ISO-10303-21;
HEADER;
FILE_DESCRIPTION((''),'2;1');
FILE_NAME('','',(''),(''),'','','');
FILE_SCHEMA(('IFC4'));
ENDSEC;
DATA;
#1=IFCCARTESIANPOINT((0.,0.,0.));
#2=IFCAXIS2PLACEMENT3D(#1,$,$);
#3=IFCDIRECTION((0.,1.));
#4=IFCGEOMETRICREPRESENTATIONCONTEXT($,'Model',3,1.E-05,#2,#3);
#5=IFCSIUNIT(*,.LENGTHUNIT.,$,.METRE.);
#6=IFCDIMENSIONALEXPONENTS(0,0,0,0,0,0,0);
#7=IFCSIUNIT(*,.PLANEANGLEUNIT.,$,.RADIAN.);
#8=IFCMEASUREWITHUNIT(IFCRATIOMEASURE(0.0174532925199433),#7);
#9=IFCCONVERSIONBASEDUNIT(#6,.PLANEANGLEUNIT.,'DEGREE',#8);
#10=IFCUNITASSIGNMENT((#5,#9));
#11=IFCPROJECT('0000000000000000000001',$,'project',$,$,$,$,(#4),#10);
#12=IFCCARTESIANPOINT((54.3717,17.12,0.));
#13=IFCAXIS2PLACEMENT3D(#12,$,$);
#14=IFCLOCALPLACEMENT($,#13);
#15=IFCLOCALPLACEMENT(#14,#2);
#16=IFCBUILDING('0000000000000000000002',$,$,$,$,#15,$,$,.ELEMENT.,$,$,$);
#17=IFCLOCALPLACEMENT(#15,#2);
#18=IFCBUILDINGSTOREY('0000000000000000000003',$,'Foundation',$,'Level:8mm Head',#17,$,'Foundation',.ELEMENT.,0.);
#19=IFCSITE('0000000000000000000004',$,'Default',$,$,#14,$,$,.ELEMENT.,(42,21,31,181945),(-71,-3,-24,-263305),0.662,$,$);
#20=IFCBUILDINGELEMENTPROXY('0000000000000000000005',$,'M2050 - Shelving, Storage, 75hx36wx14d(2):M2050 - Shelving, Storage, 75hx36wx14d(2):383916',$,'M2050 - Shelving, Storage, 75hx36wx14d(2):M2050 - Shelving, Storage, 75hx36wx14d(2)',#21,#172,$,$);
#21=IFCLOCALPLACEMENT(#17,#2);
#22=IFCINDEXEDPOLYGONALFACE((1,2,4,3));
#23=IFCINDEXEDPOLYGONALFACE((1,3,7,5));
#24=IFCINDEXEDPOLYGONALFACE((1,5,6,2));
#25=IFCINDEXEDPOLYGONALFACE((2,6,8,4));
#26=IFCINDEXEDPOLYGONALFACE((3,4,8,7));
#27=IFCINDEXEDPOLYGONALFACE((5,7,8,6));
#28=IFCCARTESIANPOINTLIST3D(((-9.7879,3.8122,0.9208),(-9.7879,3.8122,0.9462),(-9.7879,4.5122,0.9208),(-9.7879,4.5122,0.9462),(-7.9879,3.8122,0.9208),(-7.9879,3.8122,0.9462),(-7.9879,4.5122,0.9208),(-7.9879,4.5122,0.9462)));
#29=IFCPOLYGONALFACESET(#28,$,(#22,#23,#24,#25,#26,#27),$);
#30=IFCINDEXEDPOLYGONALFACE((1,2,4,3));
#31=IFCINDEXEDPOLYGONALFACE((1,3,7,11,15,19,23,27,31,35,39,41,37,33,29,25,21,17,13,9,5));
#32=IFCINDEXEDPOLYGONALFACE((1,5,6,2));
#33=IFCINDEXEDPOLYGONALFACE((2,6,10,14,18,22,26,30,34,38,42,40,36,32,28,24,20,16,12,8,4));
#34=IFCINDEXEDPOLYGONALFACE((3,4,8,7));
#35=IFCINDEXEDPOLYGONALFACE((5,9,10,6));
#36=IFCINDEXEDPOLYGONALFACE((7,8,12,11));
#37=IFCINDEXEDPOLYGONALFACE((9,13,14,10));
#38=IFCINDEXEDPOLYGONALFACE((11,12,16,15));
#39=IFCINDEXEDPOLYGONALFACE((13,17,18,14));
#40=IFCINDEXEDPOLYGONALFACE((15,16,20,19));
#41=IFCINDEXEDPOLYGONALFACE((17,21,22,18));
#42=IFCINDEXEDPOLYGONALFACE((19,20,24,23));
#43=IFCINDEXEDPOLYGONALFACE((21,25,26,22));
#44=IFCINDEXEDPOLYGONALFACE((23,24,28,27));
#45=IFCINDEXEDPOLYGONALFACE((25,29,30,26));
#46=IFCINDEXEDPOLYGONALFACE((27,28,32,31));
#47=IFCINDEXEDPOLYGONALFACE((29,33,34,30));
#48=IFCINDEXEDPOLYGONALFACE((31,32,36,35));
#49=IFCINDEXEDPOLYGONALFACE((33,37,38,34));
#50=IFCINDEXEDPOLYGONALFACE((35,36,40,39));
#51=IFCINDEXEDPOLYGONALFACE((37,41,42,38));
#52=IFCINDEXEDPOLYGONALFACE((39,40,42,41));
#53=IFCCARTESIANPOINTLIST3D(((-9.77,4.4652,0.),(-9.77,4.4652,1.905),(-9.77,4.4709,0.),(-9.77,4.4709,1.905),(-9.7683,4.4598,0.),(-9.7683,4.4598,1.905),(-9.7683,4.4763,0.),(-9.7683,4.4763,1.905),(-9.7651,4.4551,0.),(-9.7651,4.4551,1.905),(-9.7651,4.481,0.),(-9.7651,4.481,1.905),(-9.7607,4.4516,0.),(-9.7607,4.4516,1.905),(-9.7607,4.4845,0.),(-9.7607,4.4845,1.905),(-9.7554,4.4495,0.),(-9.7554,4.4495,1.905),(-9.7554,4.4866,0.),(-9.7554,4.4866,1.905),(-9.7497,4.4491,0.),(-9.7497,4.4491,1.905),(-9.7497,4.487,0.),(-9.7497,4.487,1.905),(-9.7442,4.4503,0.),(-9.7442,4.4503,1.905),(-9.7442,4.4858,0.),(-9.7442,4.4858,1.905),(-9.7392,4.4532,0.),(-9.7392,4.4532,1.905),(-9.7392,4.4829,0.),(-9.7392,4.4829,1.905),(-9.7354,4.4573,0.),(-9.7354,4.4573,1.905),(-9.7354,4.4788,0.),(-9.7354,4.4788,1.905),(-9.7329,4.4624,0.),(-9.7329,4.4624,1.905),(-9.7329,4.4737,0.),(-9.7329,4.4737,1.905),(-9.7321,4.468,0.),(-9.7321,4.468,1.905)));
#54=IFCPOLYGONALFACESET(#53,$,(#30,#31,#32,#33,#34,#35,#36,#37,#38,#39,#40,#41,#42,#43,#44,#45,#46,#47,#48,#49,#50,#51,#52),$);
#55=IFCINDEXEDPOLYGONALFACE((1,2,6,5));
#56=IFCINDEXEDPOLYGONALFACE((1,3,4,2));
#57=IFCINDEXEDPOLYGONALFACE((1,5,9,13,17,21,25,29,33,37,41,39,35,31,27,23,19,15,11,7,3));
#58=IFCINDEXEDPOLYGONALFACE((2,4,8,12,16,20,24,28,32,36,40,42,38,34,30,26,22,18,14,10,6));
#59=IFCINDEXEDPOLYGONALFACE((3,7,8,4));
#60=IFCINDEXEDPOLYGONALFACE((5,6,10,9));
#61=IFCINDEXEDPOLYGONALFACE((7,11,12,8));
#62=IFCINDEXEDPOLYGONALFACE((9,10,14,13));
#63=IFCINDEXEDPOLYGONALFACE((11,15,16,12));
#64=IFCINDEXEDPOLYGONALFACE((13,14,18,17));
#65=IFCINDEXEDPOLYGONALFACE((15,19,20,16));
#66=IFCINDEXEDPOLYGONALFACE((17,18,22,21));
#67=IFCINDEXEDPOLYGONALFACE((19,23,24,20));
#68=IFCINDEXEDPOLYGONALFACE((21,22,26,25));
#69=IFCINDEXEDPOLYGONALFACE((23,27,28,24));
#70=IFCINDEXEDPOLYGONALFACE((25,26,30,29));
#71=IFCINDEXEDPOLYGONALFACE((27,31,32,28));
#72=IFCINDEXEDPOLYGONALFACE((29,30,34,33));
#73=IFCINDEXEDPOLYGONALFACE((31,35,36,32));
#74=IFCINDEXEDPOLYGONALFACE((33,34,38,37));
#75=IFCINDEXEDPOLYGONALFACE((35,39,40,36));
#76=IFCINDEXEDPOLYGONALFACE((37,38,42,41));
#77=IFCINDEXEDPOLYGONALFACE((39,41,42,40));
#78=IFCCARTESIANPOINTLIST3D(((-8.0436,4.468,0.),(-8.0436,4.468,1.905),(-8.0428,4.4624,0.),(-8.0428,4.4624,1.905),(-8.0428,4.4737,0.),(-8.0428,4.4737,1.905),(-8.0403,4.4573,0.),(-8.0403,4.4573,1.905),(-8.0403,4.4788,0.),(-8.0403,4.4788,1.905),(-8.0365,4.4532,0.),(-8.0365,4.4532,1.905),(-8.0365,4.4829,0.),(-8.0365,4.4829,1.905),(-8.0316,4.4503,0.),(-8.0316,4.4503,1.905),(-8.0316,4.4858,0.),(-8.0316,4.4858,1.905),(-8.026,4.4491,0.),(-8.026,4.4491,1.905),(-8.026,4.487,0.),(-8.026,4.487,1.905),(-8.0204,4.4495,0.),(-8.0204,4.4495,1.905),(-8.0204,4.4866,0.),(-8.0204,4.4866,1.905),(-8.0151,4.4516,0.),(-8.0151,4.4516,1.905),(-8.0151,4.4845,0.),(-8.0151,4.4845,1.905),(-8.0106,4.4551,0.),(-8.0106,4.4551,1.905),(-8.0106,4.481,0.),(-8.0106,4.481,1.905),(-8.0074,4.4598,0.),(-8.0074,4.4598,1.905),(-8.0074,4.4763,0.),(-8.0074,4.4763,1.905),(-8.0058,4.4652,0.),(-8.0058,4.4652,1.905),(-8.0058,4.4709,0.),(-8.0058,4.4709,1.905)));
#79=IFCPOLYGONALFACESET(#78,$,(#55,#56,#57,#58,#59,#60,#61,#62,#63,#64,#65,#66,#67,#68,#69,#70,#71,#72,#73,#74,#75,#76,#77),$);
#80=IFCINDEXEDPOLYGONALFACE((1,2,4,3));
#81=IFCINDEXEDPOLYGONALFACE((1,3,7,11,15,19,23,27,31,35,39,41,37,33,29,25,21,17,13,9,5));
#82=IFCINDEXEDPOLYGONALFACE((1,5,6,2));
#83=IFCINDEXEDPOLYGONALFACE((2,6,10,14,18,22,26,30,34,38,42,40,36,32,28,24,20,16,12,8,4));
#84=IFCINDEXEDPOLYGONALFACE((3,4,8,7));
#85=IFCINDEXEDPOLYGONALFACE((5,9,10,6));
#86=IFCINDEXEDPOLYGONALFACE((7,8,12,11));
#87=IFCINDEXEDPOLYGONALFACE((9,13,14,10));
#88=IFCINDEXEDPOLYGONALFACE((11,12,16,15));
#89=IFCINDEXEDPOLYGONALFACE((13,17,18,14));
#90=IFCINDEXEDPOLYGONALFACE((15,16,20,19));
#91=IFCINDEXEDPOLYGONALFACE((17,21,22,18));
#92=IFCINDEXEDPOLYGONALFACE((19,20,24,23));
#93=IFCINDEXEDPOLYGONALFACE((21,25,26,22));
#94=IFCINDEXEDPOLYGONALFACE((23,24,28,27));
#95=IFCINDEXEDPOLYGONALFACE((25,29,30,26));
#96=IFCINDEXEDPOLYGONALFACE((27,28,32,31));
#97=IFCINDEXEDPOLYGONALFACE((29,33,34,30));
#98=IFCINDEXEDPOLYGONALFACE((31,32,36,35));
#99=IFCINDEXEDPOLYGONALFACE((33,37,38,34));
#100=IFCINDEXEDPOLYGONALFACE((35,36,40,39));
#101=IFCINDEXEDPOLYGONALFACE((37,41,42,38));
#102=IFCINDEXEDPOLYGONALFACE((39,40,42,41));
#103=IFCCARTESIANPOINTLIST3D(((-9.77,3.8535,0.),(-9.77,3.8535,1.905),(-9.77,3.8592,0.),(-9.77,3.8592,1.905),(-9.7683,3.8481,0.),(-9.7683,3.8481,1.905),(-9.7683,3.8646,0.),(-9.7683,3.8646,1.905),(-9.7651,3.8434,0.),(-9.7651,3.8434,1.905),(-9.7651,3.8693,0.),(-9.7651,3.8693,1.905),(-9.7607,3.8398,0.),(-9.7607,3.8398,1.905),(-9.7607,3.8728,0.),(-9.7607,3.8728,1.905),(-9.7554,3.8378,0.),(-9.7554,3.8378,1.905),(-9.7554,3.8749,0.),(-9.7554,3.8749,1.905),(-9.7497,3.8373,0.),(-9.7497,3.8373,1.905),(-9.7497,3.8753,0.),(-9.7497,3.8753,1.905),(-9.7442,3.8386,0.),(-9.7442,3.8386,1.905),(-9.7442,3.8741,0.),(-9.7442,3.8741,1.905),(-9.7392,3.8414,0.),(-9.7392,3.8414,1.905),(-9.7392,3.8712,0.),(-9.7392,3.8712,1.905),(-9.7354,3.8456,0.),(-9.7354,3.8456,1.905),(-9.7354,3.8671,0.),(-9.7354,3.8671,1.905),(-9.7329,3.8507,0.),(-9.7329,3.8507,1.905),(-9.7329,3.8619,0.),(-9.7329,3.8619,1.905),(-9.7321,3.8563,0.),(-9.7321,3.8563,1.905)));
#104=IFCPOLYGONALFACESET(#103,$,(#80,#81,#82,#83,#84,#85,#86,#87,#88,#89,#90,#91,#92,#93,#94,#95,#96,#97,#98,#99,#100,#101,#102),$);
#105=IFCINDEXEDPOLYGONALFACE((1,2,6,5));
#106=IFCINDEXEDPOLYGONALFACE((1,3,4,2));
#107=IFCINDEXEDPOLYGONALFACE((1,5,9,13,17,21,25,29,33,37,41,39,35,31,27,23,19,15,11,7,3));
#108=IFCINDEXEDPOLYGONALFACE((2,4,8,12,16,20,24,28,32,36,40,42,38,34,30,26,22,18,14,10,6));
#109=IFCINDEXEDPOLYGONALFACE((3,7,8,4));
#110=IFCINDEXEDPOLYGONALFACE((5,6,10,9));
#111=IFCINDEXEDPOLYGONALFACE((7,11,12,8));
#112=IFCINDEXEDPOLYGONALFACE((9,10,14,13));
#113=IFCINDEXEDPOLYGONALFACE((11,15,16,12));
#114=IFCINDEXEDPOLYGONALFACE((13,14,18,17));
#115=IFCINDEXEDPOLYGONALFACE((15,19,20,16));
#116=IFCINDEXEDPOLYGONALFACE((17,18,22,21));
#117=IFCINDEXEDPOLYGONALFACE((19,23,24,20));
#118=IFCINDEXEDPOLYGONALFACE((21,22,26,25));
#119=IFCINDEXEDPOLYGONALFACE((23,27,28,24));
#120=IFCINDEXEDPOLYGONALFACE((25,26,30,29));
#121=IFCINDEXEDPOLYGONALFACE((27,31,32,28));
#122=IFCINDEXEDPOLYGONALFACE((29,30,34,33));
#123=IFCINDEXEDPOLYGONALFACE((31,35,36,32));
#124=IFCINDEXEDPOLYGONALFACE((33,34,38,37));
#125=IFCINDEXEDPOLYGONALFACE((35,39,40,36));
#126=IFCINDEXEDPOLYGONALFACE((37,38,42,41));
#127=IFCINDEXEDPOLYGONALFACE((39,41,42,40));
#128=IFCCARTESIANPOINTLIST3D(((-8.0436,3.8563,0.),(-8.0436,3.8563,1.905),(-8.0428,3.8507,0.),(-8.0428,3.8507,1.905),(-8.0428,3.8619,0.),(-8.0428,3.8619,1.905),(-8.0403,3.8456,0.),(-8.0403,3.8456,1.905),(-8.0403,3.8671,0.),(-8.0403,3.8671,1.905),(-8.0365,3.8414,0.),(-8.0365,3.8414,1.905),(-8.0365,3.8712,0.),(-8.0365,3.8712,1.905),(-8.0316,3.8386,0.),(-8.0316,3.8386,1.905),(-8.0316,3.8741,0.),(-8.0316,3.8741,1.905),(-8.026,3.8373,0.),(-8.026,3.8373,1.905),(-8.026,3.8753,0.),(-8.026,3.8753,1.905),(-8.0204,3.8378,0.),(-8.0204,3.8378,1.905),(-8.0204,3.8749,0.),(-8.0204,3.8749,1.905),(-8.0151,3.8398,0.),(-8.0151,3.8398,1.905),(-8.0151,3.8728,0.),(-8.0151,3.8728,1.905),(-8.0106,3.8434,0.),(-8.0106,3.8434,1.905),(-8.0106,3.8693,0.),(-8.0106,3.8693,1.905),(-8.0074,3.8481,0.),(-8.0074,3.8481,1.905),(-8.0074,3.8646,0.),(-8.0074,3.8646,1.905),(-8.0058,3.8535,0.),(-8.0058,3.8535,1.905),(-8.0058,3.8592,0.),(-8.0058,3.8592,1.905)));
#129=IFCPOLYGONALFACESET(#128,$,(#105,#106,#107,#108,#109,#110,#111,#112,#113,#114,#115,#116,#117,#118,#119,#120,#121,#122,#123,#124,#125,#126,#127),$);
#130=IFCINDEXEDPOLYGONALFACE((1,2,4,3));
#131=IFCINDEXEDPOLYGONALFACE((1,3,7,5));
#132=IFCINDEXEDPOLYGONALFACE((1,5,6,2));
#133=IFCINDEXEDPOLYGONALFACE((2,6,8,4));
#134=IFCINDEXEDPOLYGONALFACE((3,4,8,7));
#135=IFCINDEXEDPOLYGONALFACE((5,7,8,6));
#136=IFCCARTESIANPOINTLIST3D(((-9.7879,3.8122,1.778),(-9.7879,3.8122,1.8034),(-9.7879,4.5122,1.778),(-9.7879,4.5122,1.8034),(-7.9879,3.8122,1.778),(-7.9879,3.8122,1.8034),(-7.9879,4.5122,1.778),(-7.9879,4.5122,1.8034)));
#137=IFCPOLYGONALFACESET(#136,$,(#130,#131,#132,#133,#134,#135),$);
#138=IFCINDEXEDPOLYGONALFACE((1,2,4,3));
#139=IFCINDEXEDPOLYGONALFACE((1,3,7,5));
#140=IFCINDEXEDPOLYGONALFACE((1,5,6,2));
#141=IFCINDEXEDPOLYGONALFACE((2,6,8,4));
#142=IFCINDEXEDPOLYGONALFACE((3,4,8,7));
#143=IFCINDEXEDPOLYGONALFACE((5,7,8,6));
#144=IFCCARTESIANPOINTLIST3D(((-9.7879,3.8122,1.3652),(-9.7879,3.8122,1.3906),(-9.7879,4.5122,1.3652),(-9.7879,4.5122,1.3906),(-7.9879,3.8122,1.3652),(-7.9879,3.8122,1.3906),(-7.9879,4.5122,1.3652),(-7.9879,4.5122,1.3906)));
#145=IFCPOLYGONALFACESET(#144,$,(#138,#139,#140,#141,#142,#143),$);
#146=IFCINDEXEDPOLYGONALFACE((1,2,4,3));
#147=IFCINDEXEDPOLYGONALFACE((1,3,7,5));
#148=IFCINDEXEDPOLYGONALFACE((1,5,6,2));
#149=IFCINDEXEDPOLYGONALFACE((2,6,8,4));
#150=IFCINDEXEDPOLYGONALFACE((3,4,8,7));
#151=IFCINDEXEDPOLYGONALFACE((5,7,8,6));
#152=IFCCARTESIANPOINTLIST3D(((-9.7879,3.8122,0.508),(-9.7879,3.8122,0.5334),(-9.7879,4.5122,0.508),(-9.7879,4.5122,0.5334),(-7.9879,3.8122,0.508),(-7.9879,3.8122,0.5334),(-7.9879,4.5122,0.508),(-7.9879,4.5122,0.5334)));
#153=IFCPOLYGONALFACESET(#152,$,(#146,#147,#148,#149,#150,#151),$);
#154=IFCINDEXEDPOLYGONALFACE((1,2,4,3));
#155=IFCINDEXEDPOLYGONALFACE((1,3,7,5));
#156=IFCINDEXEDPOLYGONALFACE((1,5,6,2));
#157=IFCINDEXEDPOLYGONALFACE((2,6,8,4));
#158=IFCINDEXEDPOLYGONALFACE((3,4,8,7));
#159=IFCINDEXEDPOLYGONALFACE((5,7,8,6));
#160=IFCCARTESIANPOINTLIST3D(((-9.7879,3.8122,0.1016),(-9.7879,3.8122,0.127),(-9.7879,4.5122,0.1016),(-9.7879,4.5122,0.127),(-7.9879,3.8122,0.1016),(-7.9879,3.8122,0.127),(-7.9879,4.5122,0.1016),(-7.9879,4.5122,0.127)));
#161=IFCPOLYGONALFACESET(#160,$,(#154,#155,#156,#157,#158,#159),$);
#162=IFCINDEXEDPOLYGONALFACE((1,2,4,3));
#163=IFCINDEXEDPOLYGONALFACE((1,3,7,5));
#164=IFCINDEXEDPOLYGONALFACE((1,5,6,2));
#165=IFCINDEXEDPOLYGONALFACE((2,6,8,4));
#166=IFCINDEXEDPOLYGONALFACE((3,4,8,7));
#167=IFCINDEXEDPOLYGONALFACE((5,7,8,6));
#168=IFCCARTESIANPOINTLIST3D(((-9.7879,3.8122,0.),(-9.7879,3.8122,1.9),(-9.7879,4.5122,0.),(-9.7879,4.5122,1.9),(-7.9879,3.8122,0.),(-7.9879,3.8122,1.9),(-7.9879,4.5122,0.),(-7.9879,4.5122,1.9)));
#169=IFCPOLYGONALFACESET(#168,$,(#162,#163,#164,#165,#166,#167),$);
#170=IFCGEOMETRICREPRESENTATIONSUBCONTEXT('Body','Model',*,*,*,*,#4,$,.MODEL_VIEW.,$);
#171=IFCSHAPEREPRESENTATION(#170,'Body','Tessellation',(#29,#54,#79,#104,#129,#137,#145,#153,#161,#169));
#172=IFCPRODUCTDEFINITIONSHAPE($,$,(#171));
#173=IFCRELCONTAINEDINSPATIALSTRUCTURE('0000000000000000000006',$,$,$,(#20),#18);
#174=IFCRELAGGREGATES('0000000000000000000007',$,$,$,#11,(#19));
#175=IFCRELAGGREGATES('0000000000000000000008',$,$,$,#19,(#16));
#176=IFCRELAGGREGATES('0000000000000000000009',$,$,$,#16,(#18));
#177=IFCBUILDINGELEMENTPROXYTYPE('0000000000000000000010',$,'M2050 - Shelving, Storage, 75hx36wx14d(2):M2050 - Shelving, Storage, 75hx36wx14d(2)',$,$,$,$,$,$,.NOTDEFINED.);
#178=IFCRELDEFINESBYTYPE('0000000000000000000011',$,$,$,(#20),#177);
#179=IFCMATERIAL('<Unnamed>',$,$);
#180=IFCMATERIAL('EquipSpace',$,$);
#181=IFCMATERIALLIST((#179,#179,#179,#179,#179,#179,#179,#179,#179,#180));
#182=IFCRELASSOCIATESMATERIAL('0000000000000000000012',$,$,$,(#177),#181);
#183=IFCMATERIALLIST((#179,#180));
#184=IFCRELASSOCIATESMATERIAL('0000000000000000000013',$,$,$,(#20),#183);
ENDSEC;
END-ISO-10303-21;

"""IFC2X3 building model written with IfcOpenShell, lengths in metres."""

from ifc_helpers import new_model, entity, si_unit, converted_unit, direction, frame, frame_2d, origin, origin_2d_with_axis, place, context, subcontext, project, spatial, rectangle, circle, extrude, source, transform, mapped, material, material_list, type_object, type_shapes, element, save


model = new_model("IFC2X3")

# Units and contexts
model_context = context("Model", 3, precision=1e-05, world=origin(), true_north=direction((0.0, 1.0)))
body_context = subcontext(model_context, "Body", "Model", "MODEL_VIEW")
ifc_project = project(units=[si_unit("LENGTHUNIT", "METRE"), converted_unit("PLANEANGLEUNIT", "DEGREE", entity("IfcRatioMeasure", 0.0174532925199433), si_unit("PLANEANGLEUNIT", "RADIAN"), dimensions=[0, 0, 0, 0, 0, 0, 0])], contexts=[model_context])

# Site, building, storey
site_placement = place(None, frame((54.3717, 17.12, 0.0)))
site = spatial("IfcSite", under=ifc_project, at=site_placement, Name="Default", CompositionType="ELEMENT", RefLatitude=(42, 21, 31, 181945), RefLongitude=(-71, -3, -24, -263305), RefElevation=0.662)
building_placement = place(site_placement, origin())
building = spatial("IfcBuilding", under=site, at=building_placement, CompositionType="ELEMENT")
storey_placement = place(building_placement, origin())
storey = spatial("IfcBuildingStorey", under=building, at=storey_placement, Name="Foundation", ObjectType="Level:8mm Head", LongName="Foundation", CompositionType="ELEMENT", Elevation=0.0)

# Building element proxy
ifc_material_1 = material(Name="<Unnamed>")
ifc_material_2 = material(Name="EquipSpace")
ifc_material_list_1 = material_list([ifc_material_1, ifc_material_1, ifc_material_1, ifc_material_1, ifc_material_1, ifc_material_1, ifc_material_1, ifc_material_1, ifc_material_1, ifc_material_2])
building_element_proxy_type = type_object("IfcBuildingElementProxyType", Name="M2050 - Shelving, Storage, 75hx36wx14d(2):M2050 - Shelving, Storage, 75hx36wx14d(2)", PredefinedType="NOTDEFINED", material=ifc_material_list_1)
shared_shape = source(origin(), body_context, "Body", "SweptSolid", [
    extrude(rectangle(XDim=1.8, YDim=0.7, at=origin_2d_with_axis()), frame((0.0, 0.0, 0.9207), z_axis=(0.0, 0.0, 1.0), x_axis=(-1.0, 0.0, 0.0)), (0.0, 0.0, 1.0), 0.0254),
    extrude(circle(Radius=0.0191, at=origin_2d_with_axis()), frame((0.8633, -0.3059, 0.0), z_axis=(0.0, 0.0, 1.0), x_axis=(-1.0, 0.0, 0.0)), (0.0, 0.0, 1.0), 1.905),
    extrude(circle(Radius=0.0191, at=origin_2d_with_axis()), frame((-0.8633, -0.3059, 0.0)), (0.0, 0.0, 1.0), 1.905),
    extrude(circle(Radius=0.0191, at=origin_2d_with_axis()), frame((0.8633, 0.3059, 0.0), z_axis=(0.0, 0.0, 1.0), x_axis=(-1.0, 0.0, 0.0)), (0.0, 0.0, 1.0), 1.905),
    extrude(circle(Radius=0.0191, at=origin_2d_with_axis()), frame((-0.8633, 0.3059, 0.0)), (0.0, 0.0, 1.0), 1.905),
    extrude(rectangle(XDim=1.8, YDim=0.7, at=origin_2d_with_axis()), frame((0.0, 0.0, 1.778), z_axis=(0.0, 0.0, 1.0), x_axis=(-1.0, 0.0, 0.0)), (0.0, 0.0, 1.0), 0.0254),
    extrude(rectangle(XDim=1.8, YDim=0.7, at=origin_2d_with_axis()), frame((0.0, 0.0, 1.3653), z_axis=(0.0, 0.0, 1.0), x_axis=(-1.0, 0.0, 0.0)), (0.0, 0.0, 1.0), 0.0254),
    extrude(rectangle(XDim=1.8, YDim=0.7, at=origin_2d_with_axis()), frame((0.0, 0.0, 0.508), z_axis=(0.0, 0.0, 1.0), x_axis=(-1.0, 0.0, 0.0)), (0.0, 0.0, 1.0), 0.0254),
    extrude(rectangle(XDim=1.8, YDim=0.7, at=origin_2d_with_axis()), frame((0.0, 0.0, 0.1016), z_axis=(0.0, 0.0, 1.0), x_axis=(-1.0, 0.0, 0.0)), (0.0, 0.0, 1.0), 0.0254),
    extrude(rectangle(XDim=0.7, YDim=1.8, at=frame_2d((0.0, 0.18), x_axis=(1.0, 0.0))), frame((-0.18, 0.0, 0.0), z_axis=(0.0, 0.0, 1.0), x_axis=(0.0, -1.0, 0.0)), (0.0, 0.0, 1.0), 1.9),
])
type_shapes(building_element_proxy_type, [shared_shape])
ifc_material_list_2 = material_list([ifc_material_1, ifc_material_2])
proxy_1_placement = place(storey_placement, frame((-8.8879, 4.1622, 0.0), z_axis=(0.0, 0.0, 1.0), x_axis=(-1.0, 0.0, 0.0)))
element("IfcBuildingElementProxy", 1, at=proxy_1_placement, inside=storey, type_object=building_element_proxy_type, material=ifc_material_list_2, Name="M2050 - Shelving, Storage, 75hx36wx14d(2):M2050 - Shelving, Storage, 75hx36wx14d(2):383916", ObjectType="M2050 - Shelving, Storage, 75hx36wx14d(2):M2050 - Shelving, Storage, 75hx36wx14d(2)", context=body_context, shape_type="MappedRepresentation", body=[
    mapped(shared_shape, transform((0.0, 0.0, 0.0), scale=1.0)),
])

save(model, "model.ifc")
